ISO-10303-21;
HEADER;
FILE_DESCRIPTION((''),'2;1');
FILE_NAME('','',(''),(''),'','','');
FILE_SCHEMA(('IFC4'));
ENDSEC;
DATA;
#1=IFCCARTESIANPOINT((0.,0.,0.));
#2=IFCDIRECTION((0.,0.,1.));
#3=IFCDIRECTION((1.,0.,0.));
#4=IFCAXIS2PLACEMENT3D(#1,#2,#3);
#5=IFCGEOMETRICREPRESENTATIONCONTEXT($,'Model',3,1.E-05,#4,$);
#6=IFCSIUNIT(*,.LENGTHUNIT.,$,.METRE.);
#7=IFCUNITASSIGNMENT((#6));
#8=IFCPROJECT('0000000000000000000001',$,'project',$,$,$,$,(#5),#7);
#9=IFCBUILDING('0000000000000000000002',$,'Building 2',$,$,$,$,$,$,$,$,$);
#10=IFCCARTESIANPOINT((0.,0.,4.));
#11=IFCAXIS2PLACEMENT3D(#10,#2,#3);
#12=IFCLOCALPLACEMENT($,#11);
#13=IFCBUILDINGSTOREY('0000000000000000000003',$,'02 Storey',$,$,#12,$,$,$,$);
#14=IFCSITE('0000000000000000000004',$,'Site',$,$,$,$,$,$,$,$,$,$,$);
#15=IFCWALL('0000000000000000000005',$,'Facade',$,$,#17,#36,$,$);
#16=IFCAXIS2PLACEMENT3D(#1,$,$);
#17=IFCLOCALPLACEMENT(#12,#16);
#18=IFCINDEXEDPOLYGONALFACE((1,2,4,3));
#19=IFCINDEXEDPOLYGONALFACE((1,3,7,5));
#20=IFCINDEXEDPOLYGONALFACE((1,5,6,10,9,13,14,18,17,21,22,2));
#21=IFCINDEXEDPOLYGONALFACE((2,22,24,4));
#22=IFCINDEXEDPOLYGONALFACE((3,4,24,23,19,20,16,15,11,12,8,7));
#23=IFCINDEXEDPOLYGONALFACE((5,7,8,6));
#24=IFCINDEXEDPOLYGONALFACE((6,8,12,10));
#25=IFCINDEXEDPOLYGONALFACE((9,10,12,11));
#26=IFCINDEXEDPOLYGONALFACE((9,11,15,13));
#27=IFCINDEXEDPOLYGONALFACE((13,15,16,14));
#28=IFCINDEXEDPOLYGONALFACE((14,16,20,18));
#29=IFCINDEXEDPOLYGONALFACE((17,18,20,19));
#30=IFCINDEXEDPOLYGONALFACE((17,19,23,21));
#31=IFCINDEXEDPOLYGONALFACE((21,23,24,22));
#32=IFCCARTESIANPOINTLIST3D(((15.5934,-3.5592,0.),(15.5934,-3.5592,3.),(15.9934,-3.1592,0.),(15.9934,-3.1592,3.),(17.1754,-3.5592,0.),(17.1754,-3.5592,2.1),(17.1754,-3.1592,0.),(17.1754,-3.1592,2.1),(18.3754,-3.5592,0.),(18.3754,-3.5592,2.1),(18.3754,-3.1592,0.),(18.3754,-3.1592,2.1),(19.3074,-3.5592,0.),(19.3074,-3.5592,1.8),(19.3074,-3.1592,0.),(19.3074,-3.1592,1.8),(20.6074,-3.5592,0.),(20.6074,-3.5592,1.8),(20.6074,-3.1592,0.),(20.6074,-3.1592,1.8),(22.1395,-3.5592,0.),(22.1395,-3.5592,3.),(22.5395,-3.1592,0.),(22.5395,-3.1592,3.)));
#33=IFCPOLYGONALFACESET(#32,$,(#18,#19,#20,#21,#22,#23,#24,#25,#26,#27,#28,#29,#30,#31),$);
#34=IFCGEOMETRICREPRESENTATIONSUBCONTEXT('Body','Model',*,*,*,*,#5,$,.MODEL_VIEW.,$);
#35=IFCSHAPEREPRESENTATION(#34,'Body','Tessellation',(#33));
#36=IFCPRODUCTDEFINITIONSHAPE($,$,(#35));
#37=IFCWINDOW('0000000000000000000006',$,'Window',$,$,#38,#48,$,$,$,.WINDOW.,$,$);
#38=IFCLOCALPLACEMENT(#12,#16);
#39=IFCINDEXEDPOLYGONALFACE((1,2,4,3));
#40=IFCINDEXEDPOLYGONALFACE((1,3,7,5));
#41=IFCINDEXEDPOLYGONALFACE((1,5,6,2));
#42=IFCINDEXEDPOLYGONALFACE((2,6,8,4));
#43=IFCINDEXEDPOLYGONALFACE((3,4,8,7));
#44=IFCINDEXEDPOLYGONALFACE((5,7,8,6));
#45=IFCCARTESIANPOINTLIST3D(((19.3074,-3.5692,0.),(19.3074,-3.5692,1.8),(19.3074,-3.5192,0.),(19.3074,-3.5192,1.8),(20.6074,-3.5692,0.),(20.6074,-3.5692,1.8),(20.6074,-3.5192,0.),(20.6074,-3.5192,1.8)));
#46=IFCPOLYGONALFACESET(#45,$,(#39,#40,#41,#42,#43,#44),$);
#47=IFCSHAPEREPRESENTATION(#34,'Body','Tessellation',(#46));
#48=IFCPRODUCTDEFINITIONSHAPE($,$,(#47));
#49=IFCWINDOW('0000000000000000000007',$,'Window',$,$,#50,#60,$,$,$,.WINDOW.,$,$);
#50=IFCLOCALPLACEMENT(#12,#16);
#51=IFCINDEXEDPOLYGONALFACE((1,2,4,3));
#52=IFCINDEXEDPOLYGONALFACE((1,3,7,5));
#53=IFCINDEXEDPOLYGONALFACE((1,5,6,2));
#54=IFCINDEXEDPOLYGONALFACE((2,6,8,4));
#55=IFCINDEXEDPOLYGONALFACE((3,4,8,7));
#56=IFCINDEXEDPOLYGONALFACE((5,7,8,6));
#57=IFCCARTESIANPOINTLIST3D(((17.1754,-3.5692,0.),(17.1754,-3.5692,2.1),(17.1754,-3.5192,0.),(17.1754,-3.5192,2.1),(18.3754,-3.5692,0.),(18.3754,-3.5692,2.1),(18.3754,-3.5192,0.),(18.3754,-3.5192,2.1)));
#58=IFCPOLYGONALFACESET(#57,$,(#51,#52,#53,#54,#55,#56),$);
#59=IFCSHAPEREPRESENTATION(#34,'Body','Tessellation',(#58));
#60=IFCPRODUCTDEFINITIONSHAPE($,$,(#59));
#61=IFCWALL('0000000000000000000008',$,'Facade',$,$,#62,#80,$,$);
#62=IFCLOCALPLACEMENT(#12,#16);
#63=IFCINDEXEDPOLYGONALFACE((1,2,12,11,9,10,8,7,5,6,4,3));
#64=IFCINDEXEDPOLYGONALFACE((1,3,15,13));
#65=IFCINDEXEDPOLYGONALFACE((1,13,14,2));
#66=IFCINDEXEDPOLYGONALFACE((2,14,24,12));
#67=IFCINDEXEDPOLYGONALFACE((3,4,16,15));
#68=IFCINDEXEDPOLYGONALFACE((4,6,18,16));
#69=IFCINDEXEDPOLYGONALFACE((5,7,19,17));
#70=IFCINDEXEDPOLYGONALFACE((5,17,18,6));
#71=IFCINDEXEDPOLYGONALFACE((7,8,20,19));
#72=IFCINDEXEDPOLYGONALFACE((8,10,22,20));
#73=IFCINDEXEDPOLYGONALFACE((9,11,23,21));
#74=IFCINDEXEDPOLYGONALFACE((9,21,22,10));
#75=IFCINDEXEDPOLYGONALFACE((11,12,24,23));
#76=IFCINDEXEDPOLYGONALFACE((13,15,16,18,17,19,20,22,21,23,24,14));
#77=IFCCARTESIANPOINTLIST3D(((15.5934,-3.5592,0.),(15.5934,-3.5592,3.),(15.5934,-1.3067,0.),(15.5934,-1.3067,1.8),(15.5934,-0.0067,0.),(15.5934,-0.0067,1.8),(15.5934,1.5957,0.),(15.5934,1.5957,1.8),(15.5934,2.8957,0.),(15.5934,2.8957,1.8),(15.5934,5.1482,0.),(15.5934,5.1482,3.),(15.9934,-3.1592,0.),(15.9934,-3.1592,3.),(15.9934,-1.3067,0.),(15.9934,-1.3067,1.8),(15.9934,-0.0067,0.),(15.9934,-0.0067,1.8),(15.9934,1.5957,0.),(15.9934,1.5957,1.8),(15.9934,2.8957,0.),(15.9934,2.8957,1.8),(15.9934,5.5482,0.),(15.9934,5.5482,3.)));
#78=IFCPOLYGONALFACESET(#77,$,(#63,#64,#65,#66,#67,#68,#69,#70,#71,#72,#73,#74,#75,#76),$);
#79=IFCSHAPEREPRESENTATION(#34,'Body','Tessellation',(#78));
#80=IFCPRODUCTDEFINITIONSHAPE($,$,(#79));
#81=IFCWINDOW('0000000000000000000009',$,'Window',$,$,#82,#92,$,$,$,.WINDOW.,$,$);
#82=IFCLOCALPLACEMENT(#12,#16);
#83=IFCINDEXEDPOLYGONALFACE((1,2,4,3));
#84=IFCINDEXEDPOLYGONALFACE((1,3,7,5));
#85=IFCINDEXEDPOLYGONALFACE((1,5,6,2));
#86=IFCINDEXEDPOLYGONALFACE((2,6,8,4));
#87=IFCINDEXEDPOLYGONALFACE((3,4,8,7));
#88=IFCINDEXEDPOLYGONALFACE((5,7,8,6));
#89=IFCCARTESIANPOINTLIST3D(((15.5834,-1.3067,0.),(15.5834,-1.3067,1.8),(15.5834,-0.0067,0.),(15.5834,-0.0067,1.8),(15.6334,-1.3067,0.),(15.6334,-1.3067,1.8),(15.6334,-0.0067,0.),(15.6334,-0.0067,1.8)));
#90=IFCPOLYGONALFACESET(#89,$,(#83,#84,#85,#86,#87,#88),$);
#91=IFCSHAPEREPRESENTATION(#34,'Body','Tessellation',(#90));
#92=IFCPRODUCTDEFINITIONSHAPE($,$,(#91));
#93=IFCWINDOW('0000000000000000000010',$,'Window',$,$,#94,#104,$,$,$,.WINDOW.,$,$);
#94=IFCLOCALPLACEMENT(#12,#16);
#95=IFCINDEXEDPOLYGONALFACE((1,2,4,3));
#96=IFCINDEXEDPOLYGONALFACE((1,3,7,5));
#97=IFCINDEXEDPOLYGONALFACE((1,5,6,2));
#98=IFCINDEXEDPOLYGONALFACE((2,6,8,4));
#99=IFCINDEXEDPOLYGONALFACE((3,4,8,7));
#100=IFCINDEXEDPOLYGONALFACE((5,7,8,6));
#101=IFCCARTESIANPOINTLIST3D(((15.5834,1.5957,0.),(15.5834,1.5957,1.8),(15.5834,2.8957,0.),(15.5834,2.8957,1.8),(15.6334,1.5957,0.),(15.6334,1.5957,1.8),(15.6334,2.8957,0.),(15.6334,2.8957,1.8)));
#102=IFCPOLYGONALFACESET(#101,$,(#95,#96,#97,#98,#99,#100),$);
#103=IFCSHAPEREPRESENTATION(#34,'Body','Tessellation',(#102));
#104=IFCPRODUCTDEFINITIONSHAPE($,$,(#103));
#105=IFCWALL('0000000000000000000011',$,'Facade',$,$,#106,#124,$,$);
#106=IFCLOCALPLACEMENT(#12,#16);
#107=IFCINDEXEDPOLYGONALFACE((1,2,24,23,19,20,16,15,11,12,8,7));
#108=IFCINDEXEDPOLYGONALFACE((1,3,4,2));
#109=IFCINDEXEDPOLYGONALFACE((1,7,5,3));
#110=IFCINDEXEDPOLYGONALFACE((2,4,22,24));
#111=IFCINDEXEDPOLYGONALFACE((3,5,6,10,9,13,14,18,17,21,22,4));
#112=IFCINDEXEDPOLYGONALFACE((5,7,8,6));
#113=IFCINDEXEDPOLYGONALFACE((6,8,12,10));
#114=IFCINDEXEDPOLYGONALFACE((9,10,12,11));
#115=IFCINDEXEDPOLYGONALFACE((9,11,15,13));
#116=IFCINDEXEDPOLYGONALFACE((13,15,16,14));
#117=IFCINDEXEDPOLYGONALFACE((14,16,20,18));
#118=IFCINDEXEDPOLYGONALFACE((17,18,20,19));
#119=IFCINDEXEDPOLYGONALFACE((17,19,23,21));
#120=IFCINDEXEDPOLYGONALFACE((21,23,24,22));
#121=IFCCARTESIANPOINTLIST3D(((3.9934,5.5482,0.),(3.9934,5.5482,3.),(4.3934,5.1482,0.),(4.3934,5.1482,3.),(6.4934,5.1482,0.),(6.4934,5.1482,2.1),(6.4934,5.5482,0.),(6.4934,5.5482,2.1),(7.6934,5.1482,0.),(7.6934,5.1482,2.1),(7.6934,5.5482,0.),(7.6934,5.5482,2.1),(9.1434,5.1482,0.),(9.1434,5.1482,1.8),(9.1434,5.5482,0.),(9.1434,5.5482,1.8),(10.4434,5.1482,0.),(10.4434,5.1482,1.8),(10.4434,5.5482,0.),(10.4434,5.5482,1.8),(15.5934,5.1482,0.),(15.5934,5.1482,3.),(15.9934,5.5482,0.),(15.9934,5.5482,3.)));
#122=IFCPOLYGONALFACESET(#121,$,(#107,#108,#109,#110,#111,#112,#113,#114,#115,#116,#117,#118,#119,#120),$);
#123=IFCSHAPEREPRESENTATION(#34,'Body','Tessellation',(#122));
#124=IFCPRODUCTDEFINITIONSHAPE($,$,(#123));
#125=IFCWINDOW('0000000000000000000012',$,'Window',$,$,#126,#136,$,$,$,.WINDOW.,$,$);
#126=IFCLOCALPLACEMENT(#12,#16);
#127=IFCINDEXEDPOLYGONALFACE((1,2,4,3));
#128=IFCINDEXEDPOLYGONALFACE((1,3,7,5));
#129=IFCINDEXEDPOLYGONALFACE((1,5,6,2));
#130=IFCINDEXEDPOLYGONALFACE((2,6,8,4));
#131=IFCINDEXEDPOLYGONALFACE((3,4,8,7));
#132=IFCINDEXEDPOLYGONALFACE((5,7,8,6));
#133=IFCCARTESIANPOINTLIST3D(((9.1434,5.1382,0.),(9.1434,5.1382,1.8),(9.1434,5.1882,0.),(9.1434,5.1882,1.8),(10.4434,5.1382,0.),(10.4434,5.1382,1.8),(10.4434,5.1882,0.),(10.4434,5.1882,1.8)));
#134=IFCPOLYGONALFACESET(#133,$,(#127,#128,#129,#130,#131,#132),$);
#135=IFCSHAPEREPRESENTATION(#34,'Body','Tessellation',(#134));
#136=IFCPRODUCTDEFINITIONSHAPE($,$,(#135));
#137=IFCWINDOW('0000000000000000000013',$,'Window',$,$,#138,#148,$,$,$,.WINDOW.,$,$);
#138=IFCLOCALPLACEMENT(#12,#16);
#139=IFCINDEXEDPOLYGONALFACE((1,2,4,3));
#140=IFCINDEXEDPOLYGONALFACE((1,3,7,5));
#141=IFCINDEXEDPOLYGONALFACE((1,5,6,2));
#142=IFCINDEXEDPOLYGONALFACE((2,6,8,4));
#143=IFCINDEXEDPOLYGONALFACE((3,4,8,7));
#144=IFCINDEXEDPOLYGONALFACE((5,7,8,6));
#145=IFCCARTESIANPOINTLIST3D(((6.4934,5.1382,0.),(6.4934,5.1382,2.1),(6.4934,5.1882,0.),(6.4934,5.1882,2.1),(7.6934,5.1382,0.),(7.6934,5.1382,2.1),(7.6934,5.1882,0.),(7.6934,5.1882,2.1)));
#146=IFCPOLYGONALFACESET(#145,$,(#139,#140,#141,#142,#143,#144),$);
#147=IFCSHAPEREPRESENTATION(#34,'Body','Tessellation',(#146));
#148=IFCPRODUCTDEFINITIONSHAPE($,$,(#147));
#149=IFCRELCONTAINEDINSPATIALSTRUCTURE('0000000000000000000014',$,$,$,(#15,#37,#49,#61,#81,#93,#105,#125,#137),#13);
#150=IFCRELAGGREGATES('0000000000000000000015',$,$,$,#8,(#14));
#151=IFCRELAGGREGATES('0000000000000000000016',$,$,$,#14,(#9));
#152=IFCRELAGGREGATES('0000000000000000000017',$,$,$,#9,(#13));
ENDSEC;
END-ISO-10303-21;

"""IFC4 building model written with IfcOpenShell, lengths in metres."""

from ifc_helpers import new_model, si_unit, frame, origin_with_axes, place, context, subcontext, project, spatial, line, indexed_curve, outline, extrude, element, fill, save


model = new_model("IFC4")

# Units and contexts
model_context = context("Model", 3, precision=1e-05, world=origin_with_axes())
body_context = subcontext(model_context, "Body", "Model", "MODEL_VIEW")
ifc_project = project(units=[si_unit("LENGTHUNIT", "METRE")], contexts=[model_context])

# Site, building, storey
site = spatial("IfcSite", under=ifc_project, Name="Site")
building = spatial("IfcBuilding", under=site, Name="Building 2")
storey_placement = place(None, frame((0.0, 0.0, 4.0), z_axis=(0.0, 0.0, 1.0), x_axis=(1.0, 0.0, 0.0)))
storey = spatial("IfcBuildingStorey", under=building, at=storey_placement, Name="02 Storey")

# Walls, openings, windows
wall_1_placement = place(storey_placement, origin_with_axes())
wall_1 = element("IfcWall", 1, at=wall_1_placement, inside=storey, Name="Facade", context=body_context, shape_type="SweptSolid", body=[
    extrude(outline(indexed_curve([(22.1395, -3.5592), (15.5934, -3.5592), (15.9934, -3.1592), (22.5395, -3.1592)], segments=[line(1, 2), line(2, 3), line(3, 4)])), origin_with_axes(), (0.0, 0.0, 1.0), 3.0),
])
opening_1_placement = place(wall_1_placement, origin_with_axes())
opening_1 = element("IfcOpeningElement", 2, at=opening_1_placement, cuts=wall_1, context=body_context, shape_type="SweptSolid", body=[
    extrude(outline(indexed_curve([(20.6074, -3.1192), (20.6074, -3.6192), (19.3074, -3.6192), (19.3074, -3.1192)], segments=[line(1, 2), line(2, 3), line(3, 4)])), origin_with_axes(), (0.0, 0.0, 1.0), 1.8),
])
opening_2_placement = place(wall_1_placement, origin_with_axes())
opening_2 = element("IfcOpeningElement", 3, at=opening_2_placement, cuts=wall_1, context=body_context, shape_type="SweptSolid", body=[
    extrude(outline(indexed_curve([(18.3754, -3.1192), (18.3754, -3.6192), (17.1754, -3.6192), (17.1754, -3.1192)], segments=[line(1, 2), line(2, 3), line(3, 4)])), origin_with_axes(), (0.0, 0.0, 1.0), 2.1),
])
window_1_placement = place(storey_placement, origin_with_axes())
window_1 = element("IfcWindow", 4, at=window_1_placement, inside=storey, Name="Window", PredefinedType="WINDOW", context=body_context, shape_type="SweptSolid", body=[
    extrude(outline(indexed_curve([(20.6074, -3.5192), (20.6074, -3.5692), (19.3074, -3.5692), (19.3074, -3.5192)], segments=[line(1, 2), line(2, 3), line(3, 4)])), origin_with_axes(), (0.0, 0.0, 1.0), 1.8),
])
fill(opening_1, window_1)
window_2_placement = place(storey_placement, origin_with_axes())
window_2 = element("IfcWindow", 5, at=window_2_placement, inside=storey, Name="Window", PredefinedType="WINDOW", context=body_context, shape_type="SweptSolid", body=[
    extrude(outline(indexed_curve([(18.3754, -3.5192), (18.3754, -3.5692), (17.1754, -3.5692), (17.1754, -3.5192)], segments=[line(1, 2), line(2, 3), line(3, 4)])), origin_with_axes(), (0.0, 0.0, 1.0), 2.1),
])
fill(opening_2, window_2)
wall_2_placement = place(storey_placement, origin_with_axes())
wall_2 = element("IfcWall", 6, at=wall_2_placement, inside=storey, Name="Facade", context=body_context, shape_type="SweptSolid", body=[
    extrude(outline(indexed_curve([(15.5934, -3.5592), (15.5934, 5.1482), (15.9934, 5.5482), (15.9934, -3.1592)], segments=[line(1, 2), line(2, 3), line(3, 4)])), origin_with_axes(), (0.0, 0.0, 1.0), 3.0),
])
opening_3_placement = place(wall_2_placement, origin_with_axes())
opening_3 = element("IfcOpeningElement", 7, at=opening_3_placement, cuts=wall_2, context=body_context, shape_type="SweptSolid", body=[
    extrude(outline(indexed_curve([(16.0334, -1.3067), (15.5334, -1.3067), (15.5334, -0.0067), (16.0334, -0.0067)], segments=[line(1, 2), line(2, 3), line(3, 4)])), origin_with_axes(), (0.0, 0.0, 1.0), 1.8),
])
opening_4_placement = place(wall_2_placement, origin_with_axes())
opening_4 = element("IfcOpeningElement", 8, at=opening_4_placement, cuts=wall_2, context=body_context, shape_type="SweptSolid", body=[
    extrude(outline(indexed_curve([(16.0334, 1.5957), (15.5334, 1.5957), (15.5334, 2.8957), (16.0334, 2.8957)], segments=[line(1, 2), line(2, 3), line(3, 4)])), origin_with_axes(), (0.0, 0.0, 1.0), 1.8),
])
window_3_placement = place(storey_placement, origin_with_axes())
window_3 = element("IfcWindow", 9, at=window_3_placement, inside=storey, Name="Window", PredefinedType="WINDOW", context=body_context, shape_type="SweptSolid", body=[
    extrude(outline(indexed_curve([(15.6334, -1.3067), (15.5834, -1.3067), (15.5834, -0.0067), (15.6334, -0.0067)], segments=[line(1, 2), line(2, 3), line(3, 4)])), origin_with_axes(), (0.0, 0.0, 1.0), 1.8),
])
fill(opening_3, window_3)
window_4_placement = place(storey_placement, origin_with_axes())
window_4 = element("IfcWindow", 10, at=window_4_placement, inside=storey, Name="Window", PredefinedType="WINDOW", context=body_context, shape_type="SweptSolid", body=[
    extrude(outline(indexed_curve([(15.6334, 1.5957), (15.5834, 1.5957), (15.5834, 2.8957), (15.6334, 2.8957)], segments=[line(1, 2), line(2, 3), line(3, 4)])), origin_with_axes(), (0.0, 0.0, 1.0), 1.8),
])
fill(opening_4, window_4)
wall_3_placement = place(storey_placement, origin_with_axes())
wall_3 = element("IfcWall", 11, at=wall_3_placement, inside=storey, Name="Facade", context=body_context, shape_type="SweptSolid", body=[
    extrude(outline(indexed_curve([(15.5934, 5.1482), (4.3934, 5.1482), (3.9934, 5.5482), (15.9934, 5.5482)], segments=[line(1, 2), line(2, 3), line(3, 4)])), origin_with_axes(), (0.0, 0.0, 1.0), 3.0),
])
opening_5_placement = place(wall_3_placement, origin_with_axes())
opening_5 = element("IfcOpeningElement", 12, at=opening_5_placement, cuts=wall_3, context=body_context, shape_type="SweptSolid", body=[
    extrude(outline(indexed_curve([(10.4434, 5.5882), (10.4434, 5.0882), (9.1434, 5.0882), (9.1434, 5.5882)], segments=[line(1, 2), line(2, 3), line(3, 4)])), origin_with_axes(), (0.0, 0.0, 1.0), 1.8),
])
opening_6_placement = place(wall_3_placement, origin_with_axes())
opening_6 = element("IfcOpeningElement", 13, at=opening_6_placement, cuts=wall_3, context=body_context, shape_type="SweptSolid", body=[
    extrude(outline(indexed_curve([(7.6934, 5.5882), (7.6934, 5.0882), (6.4934, 5.0882), (6.4934, 5.5882)], segments=[line(1, 2), line(2, 3), line(3, 4)])), origin_with_axes(), (0.0, 0.0, 1.0), 2.1),
])
window_5_placement = place(storey_placement, origin_with_axes())
window_5 = element("IfcWindow", 14, at=window_5_placement, inside=storey, Name="Window", PredefinedType="WINDOW", context=body_context, shape_type="SweptSolid", body=[
    extrude(outline(indexed_curve([(10.4434, 5.1882), (10.4434, 5.1382), (9.1434, 5.1382), (9.1434, 5.1882)], segments=[line(1, 2), line(2, 3), line(3, 4)])), origin_with_axes(), (0.0, 0.0, 1.0), 1.8),
])
fill(opening_5, window_5)
window_6_placement = place(storey_placement, origin_with_axes())
window_6 = element("IfcWindow", 15, at=window_6_placement, inside=storey, Name="Window", PredefinedType="WINDOW", context=body_context, shape_type="SweptSolid", body=[
    extrude(outline(indexed_curve([(7.6934, 5.1882), (7.6934, 5.1382), (6.4934, 5.1382), (6.4934, 5.1882)], segments=[line(1, 2), line(2, 3), line(3, 4)])), origin_with_axes(), (0.0, 0.0, 1.0), 2.1),
])
fill(opening_6, window_6)

save(model, "model.ifc")
